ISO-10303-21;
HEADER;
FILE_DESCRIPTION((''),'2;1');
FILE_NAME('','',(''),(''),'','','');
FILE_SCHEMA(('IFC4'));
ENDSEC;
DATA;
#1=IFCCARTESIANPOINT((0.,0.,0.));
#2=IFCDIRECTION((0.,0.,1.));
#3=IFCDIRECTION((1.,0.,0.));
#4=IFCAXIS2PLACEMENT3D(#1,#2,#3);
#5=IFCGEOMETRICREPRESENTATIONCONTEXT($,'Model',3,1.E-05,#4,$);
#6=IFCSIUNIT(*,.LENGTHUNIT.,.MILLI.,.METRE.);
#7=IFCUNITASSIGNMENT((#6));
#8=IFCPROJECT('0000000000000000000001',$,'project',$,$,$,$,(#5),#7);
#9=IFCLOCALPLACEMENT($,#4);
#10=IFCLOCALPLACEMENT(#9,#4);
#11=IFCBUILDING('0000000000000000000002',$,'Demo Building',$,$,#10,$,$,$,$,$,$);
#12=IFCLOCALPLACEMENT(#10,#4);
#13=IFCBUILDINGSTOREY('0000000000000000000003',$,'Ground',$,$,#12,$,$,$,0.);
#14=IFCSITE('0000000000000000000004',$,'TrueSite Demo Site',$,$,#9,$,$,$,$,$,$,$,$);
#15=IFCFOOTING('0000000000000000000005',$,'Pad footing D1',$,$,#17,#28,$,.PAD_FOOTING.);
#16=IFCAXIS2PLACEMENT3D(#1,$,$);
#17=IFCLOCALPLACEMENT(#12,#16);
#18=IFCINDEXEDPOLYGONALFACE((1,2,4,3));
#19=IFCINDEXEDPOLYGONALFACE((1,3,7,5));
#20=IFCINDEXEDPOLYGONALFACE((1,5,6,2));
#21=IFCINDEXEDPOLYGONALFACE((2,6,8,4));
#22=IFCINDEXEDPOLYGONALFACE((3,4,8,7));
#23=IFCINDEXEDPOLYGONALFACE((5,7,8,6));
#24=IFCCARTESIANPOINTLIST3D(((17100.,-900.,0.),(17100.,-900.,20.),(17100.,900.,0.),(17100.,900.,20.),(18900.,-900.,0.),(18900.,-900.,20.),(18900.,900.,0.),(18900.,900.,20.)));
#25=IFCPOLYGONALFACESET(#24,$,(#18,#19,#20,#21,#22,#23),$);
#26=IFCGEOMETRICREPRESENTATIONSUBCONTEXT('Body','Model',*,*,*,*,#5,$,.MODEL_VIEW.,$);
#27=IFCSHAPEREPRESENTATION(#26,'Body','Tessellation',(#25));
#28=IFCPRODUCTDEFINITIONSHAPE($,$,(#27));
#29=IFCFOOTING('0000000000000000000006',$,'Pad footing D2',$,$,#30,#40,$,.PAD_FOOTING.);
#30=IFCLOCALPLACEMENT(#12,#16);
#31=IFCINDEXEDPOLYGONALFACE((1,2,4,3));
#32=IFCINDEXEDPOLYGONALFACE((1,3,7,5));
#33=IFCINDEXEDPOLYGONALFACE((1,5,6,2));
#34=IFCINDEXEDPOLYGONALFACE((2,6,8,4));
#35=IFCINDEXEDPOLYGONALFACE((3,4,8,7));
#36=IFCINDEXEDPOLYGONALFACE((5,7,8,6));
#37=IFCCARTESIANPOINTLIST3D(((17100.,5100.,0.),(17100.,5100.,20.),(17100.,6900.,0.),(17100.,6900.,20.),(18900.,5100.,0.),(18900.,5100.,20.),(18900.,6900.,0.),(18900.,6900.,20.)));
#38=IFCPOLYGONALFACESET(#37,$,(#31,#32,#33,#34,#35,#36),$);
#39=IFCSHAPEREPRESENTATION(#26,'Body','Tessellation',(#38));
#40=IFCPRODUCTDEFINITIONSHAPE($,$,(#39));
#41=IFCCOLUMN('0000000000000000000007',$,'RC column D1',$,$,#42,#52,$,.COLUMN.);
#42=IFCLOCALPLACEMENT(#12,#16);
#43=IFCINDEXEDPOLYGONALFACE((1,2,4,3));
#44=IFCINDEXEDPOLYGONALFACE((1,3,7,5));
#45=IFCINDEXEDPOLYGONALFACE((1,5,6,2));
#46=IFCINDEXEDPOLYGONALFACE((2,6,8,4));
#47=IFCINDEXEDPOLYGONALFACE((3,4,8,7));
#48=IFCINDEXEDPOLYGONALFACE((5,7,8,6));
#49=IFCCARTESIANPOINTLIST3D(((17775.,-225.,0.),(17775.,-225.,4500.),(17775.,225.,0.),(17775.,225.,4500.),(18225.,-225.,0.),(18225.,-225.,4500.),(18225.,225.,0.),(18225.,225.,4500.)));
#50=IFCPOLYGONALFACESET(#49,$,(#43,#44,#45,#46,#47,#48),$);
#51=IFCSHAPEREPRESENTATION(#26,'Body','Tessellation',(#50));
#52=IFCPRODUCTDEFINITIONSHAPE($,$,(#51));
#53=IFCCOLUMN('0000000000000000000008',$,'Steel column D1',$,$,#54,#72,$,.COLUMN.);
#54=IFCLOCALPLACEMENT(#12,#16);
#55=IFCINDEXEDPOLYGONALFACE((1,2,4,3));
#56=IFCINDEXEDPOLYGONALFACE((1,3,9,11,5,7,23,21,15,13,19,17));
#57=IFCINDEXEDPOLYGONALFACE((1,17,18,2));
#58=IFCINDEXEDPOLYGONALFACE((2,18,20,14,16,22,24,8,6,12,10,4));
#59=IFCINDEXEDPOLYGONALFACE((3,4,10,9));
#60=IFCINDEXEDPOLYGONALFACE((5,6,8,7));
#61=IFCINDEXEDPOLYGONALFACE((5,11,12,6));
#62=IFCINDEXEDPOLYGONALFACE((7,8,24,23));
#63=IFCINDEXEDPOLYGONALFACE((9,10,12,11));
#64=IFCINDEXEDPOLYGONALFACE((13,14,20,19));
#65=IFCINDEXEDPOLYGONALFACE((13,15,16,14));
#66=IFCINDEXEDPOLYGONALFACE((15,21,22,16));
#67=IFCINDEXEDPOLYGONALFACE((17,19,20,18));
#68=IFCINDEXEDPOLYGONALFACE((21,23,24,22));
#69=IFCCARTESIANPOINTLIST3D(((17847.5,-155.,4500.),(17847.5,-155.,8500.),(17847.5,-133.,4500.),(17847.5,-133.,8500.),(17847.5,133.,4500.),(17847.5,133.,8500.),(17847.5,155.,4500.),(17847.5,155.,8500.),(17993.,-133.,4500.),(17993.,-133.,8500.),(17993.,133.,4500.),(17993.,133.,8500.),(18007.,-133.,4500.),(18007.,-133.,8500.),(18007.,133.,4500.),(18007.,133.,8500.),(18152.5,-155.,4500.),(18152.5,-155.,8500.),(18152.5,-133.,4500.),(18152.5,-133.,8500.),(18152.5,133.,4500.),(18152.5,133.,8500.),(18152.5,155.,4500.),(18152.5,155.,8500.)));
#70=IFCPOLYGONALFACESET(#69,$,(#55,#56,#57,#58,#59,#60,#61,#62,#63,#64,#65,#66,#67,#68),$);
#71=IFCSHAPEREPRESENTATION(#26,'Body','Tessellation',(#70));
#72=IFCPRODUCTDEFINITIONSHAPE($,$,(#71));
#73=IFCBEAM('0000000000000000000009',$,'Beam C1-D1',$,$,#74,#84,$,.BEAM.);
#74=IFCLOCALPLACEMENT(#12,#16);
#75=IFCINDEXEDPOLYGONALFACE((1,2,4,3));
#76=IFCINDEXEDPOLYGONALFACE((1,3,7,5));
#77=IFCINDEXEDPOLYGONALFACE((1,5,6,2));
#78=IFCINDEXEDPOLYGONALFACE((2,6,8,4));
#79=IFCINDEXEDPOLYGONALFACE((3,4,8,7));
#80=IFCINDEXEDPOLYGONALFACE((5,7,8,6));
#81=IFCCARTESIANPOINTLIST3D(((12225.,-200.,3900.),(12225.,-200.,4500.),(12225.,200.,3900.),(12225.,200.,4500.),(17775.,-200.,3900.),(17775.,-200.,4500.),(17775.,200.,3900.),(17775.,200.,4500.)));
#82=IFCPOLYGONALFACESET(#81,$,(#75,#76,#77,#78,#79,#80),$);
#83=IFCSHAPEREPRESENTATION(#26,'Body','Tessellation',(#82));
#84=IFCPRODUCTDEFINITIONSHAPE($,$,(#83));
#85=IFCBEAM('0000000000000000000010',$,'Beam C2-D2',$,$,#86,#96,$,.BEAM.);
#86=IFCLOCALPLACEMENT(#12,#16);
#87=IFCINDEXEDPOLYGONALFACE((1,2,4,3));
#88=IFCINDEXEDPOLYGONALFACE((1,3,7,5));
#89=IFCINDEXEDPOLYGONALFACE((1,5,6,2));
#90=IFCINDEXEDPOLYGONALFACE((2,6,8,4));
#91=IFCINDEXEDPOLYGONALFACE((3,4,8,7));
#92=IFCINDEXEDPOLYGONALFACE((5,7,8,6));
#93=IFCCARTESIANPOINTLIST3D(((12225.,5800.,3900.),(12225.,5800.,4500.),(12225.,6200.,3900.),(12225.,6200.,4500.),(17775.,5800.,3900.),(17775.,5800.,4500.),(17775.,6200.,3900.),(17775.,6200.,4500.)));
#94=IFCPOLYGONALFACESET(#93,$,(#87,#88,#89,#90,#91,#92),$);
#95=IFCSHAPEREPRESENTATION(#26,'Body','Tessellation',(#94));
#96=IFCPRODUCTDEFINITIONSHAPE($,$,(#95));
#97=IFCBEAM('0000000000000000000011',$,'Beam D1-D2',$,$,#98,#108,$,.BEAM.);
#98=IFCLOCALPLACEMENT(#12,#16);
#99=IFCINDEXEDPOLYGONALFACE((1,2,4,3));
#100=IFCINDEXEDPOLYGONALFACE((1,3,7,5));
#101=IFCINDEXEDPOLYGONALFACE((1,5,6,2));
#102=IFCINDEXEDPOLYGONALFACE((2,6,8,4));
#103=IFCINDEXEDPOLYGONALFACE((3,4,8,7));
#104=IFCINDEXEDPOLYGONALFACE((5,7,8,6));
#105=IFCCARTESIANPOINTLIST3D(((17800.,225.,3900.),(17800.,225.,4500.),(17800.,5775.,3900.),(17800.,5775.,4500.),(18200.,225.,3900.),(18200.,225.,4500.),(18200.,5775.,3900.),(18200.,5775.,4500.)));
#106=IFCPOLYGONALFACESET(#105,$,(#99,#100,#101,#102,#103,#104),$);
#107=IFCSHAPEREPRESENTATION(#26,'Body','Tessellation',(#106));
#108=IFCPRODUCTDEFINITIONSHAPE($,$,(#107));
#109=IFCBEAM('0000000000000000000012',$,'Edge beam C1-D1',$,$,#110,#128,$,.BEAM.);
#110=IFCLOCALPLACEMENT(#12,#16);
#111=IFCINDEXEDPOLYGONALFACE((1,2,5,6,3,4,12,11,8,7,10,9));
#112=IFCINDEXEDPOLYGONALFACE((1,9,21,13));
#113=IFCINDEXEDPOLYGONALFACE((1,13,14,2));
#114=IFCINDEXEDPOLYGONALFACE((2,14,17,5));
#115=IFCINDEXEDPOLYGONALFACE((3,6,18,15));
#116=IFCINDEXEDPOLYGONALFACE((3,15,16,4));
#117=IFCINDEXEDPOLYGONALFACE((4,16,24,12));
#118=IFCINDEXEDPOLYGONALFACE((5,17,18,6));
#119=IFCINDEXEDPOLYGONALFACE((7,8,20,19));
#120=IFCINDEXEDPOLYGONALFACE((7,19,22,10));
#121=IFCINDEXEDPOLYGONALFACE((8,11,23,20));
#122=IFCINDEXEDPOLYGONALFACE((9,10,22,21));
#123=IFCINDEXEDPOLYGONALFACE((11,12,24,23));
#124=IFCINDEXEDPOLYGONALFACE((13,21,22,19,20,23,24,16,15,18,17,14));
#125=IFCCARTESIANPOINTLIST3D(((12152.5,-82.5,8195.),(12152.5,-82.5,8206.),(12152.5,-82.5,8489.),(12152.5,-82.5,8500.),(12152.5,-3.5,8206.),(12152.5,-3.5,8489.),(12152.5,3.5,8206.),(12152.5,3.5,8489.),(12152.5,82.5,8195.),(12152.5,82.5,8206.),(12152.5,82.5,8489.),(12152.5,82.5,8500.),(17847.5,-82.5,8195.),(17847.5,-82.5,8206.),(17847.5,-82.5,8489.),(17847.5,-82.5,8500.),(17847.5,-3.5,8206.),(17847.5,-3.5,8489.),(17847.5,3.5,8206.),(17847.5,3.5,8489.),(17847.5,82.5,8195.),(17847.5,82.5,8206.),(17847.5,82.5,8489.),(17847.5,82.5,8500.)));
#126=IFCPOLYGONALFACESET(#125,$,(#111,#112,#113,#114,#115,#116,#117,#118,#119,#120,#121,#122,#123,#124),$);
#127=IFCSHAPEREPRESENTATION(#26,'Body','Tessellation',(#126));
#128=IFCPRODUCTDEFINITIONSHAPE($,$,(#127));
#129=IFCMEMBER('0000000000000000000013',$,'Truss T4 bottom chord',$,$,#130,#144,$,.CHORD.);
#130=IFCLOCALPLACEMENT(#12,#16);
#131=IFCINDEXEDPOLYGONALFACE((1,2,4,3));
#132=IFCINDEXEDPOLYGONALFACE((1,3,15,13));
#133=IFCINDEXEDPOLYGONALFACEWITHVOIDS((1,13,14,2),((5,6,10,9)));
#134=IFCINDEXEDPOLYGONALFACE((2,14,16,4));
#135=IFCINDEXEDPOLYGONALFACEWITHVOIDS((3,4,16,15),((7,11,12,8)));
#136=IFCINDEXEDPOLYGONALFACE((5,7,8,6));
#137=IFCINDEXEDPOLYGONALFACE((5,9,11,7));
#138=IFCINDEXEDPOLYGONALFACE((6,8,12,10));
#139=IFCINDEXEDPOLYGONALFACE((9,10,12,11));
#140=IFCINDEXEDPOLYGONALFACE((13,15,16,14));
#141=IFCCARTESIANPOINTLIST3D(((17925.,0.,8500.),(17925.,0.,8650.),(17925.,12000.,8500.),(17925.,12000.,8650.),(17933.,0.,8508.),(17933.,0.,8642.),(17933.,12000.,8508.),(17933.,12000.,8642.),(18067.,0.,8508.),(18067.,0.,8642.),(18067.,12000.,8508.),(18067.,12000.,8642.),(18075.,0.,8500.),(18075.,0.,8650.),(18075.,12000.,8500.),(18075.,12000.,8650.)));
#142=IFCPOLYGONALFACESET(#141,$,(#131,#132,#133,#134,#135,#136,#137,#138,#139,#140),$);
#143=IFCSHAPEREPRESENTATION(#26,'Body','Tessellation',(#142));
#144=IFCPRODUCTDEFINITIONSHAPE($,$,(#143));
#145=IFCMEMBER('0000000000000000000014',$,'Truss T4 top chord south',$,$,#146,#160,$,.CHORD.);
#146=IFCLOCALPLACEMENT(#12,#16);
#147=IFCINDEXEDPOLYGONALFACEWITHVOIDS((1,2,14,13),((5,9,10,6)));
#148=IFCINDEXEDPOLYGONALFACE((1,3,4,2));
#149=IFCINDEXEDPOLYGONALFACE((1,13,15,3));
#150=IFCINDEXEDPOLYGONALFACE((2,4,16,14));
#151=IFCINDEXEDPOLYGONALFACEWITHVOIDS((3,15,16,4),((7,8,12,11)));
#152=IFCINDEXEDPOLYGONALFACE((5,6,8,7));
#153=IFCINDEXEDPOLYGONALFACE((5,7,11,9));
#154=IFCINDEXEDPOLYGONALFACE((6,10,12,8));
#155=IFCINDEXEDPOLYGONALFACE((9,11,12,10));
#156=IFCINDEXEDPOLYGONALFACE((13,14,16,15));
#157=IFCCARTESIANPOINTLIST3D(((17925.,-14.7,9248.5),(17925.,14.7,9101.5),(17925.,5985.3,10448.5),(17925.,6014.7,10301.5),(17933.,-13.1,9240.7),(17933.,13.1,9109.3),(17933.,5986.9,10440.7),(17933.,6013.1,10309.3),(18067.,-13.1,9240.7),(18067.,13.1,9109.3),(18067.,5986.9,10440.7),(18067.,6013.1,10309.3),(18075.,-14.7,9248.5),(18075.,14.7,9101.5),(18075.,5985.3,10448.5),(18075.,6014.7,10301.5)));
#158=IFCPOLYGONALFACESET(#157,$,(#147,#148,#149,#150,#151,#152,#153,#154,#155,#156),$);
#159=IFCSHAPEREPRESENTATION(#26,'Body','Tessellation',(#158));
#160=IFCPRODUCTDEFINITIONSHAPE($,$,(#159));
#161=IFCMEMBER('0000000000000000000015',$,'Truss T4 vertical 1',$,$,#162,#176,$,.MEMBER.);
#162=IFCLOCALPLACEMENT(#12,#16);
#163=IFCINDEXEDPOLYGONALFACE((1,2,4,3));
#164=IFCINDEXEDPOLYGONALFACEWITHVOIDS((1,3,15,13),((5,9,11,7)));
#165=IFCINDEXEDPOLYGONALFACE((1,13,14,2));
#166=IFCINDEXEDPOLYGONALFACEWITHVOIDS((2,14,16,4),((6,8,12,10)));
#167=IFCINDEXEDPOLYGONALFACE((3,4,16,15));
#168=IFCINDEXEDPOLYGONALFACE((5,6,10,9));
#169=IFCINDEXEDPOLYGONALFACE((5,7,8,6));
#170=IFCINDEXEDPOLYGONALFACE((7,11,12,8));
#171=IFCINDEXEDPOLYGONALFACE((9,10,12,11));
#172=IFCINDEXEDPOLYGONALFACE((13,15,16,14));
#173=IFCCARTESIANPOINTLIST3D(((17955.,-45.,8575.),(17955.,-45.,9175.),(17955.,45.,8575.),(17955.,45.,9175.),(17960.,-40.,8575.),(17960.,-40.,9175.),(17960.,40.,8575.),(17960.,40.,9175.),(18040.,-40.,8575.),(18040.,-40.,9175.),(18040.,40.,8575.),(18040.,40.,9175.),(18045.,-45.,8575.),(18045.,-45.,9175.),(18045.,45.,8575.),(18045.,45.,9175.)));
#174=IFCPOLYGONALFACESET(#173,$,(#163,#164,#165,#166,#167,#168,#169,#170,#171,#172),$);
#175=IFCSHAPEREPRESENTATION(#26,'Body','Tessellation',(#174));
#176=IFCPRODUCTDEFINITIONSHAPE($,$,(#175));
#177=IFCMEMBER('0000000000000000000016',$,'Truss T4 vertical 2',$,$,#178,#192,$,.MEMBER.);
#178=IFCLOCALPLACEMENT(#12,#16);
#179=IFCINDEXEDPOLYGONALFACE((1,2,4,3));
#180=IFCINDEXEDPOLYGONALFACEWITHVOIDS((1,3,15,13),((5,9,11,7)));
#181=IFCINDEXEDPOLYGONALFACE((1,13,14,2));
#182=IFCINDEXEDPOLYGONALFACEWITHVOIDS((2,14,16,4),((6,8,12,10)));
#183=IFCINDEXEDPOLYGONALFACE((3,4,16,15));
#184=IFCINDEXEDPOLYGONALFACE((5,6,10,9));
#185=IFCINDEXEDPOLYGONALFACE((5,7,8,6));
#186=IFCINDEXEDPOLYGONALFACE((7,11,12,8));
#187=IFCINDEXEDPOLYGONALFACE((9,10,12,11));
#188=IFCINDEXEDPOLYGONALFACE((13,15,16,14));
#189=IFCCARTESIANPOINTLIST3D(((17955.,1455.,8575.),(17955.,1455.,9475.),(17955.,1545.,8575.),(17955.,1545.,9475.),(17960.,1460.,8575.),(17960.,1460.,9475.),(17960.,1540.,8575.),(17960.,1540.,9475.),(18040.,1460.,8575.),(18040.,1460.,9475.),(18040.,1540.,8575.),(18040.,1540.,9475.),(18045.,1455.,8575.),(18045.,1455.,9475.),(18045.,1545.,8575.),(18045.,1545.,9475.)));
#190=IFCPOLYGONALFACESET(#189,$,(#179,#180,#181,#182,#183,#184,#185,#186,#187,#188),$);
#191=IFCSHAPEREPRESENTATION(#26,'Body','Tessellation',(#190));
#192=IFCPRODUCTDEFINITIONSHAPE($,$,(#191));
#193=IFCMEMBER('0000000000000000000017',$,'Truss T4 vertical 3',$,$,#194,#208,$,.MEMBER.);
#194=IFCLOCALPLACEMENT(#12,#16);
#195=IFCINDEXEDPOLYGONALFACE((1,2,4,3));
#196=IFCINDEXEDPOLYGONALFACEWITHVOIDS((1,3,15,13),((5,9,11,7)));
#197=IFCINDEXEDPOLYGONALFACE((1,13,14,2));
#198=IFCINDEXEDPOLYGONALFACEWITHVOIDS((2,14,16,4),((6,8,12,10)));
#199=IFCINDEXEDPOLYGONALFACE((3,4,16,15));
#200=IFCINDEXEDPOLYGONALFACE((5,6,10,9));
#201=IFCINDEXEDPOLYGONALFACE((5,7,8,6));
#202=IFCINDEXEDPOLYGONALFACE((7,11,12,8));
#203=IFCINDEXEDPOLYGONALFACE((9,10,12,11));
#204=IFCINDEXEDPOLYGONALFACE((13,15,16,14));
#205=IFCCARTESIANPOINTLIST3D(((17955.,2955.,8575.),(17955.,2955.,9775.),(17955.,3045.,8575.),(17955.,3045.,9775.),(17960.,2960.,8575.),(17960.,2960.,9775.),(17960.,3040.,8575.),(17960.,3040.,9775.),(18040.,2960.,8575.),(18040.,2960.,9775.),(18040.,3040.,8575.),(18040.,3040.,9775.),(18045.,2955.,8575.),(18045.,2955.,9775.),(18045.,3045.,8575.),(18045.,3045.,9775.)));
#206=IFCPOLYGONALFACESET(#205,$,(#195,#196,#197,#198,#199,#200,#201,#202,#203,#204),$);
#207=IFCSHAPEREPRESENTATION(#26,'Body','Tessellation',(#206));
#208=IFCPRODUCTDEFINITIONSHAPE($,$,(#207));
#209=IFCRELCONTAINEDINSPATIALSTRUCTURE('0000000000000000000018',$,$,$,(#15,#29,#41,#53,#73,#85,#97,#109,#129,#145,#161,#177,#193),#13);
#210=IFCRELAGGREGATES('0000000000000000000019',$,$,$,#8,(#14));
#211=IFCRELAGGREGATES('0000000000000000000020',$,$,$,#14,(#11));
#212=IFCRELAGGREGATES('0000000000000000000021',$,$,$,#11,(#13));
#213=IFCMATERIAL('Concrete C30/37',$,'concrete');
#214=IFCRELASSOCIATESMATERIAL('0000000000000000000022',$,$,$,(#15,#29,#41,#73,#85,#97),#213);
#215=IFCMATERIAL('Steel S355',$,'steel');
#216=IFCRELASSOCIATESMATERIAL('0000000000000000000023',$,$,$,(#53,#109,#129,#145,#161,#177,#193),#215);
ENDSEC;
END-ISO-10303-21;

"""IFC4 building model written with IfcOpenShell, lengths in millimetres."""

from ifc_helpers import new_model, si_unit, frame, origin_with_axes, place, context, subcontext, project, spatial, rectangle, hollow_rectangle, i_section, extrude, material, element, save


model = new_model("IFC4")

# Units and contexts
model_context = context("Model", 3, precision=1e-05, world=origin_with_axes())
body_context = subcontext(model_context, "Body", "Model", "MODEL_VIEW")
ifc_project = project(units=[si_unit("LENGTHUNIT", "METRE", prefix="MILLI")], contexts=[model_context])

# Site, building, storey
site_placement = place(None, origin_with_axes())
site = spatial("IfcSite", under=ifc_project, at=site_placement, Name="TrueSite Demo Site")
building_placement = place(site_placement, origin_with_axes())
building = spatial("IfcBuilding", under=site, at=building_placement, Name="Demo Building")
storey_placement = place(building_placement, origin_with_axes())
storey = spatial("IfcBuildingStorey", under=building, at=storey_placement, Name="Ground", Elevation=0.0)

# Footings
ifc_material_1 = material(Name="Concrete C30/37", Category="concrete")
for number, where, z_axis, x_axis, name in (
    (1, (18000.0, 0.0, 0.0), (0.0, 0.0, 1.0), (1.0, 0.0, 0.0), "Pad footing D1"),
    (2, (18000.0, 6000.0, 0.0), (0.0, 0.0, 1.0), (1.0, 0.0, 0.0), "Pad footing D2"),
):
    element("IfcFooting", number, at=place(storey_placement, frame(where, z_axis=z_axis, x_axis=x_axis)), inside=storey, material=ifc_material_1, Name=name, PredefinedType="PAD_FOOTING", context=body_context, shape_type="SweptSolid", body=[
        extrude(rectangle(XDim=1800.0, YDim=1800.0), origin_with_axes(), (0.0, 0.0, 1.0), 20.0),
    ])

# Columns
column_1_placement = place(storey_placement, frame((18000.0, 0.0, 0.0), z_axis=(0.0, 0.0, 1.0), x_axis=(1.0, 0.0, 0.0)))
element("IfcColumn", 3, at=column_1_placement, inside=storey, material=ifc_material_1, Name="RC column D1", PredefinedType="COLUMN", context=body_context, shape_type="SweptSolid", body=[
    extrude(rectangle(XDim=450.0, YDim=450.0), origin_with_axes(), (0.0, 0.0, 1.0), 4500.0),
])
ifc_material_2 = material(Name="Steel S355", Category="steel")
column_2_placement = place(storey_placement, frame((18000.0, 0.0, 4500.0), z_axis=(0.0, 0.0, 1.0), x_axis=(1.0, 0.0, 0.0)))
element("IfcColumn", 4, at=column_2_placement, inside=storey, material=ifc_material_2, Name="Steel column D1", PredefinedType="COLUMN", context=body_context, shape_type="SweptSolid", body=[
    extrude(i_section(OverallWidth=305.0, OverallDepth=310.0, WebThickness=14.0, FlangeThickness=22.0), origin_with_axes(), (0.0, 0.0, 1.0), 4000.0),
])

# Beams
for number, where, z_axis, x_axis, name in (
    (5, (12225.0, 0.0, 4200.0), (1.0, 0.0, 0.0), (0.0, 1.0, 0.0), "Beam C1-D1"),
    (6, (12225.0, 6000.0, 4200.0), (1.0, 0.0, 0.0), (0.0, 1.0, 0.0), "Beam C2-D2"),
):
    element("IfcBeam", number, at=place(storey_placement, frame(where, z_axis=z_axis, x_axis=x_axis)), inside=storey, material=ifc_material_1, Name=name, PredefinedType="BEAM", context=body_context, shape_type="SweptSolid", body=[
        extrude(rectangle(XDim=400.0, YDim=600.0), origin_with_axes(), (0.0, 0.0, 1.0), 5550.0),
    ])
beam_1_placement = place(storey_placement, frame((18000.0, 225.0, 4200.0), z_axis=(0.0, 1.0, 0.0), x_axis=(-1.0, 0.0, 0.0)))
element("IfcBeam", 7, at=beam_1_placement, inside=storey, material=ifc_material_1, Name="Beam D1-D2", PredefinedType="BEAM", context=body_context, shape_type="SweptSolid", body=[
    extrude(rectangle(XDim=400.0, YDim=600.0), origin_with_axes(), (0.0, 0.0, 1.0), 5550.0),
])
beam_2_placement = place(storey_placement, frame((12152.5, 0.0, 8347.5), z_axis=(1.0, 0.0, 0.0), x_axis=(0.0, 1.0, 0.0)))
element("IfcBeam", 8, at=beam_2_placement, inside=storey, material=ifc_material_2, Name="Edge beam C1-D1", PredefinedType="BEAM", context=body_context, shape_type="SweptSolid", body=[
    extrude(i_section(OverallWidth=165.0, OverallDepth=305.0, WebThickness=7.0, FlangeThickness=11.0), origin_with_axes(), (0.0, 0.0, 1.0), 5695.0),
])

# Members
member_1_placement = place(storey_placement, frame((18000.0, 0.0, 8575.0), z_axis=(0.0, 1.0, 0.0), x_axis=(-1.0, 0.0, 0.0)))
element("IfcMember", 9, at=member_1_placement, inside=storey, material=ifc_material_2, Name="Truss T4 bottom chord", PredefinedType="CHORD", context=body_context, shape_type="SweptSolid", body=[
    extrude(hollow_rectangle(XDim=150.0, YDim=150.0, WallThickness=8.0), origin_with_axes(), (0.0, 0.0, 1.0), 12000.0),
])
member_2_placement = place(storey_placement, frame((18000.0, 0.0, 9175.0), z_axis=(0.0, 0.980581, 0.196116), x_axis=(-1.0, 0.0, 0.0)))
element("IfcMember", 10, at=member_2_placement, inside=storey, material=ifc_material_2, Name="Truss T4 top chord south", PredefinedType="CHORD", context=body_context, shape_type="SweptSolid", body=[
    extrude(hollow_rectangle(XDim=150.0, YDim=150.0, WallThickness=8.0), origin_with_axes(), (0.0, 0.0, 1.0), 6118.8),
])
member_3_placement = place(storey_placement, frame((18000.0, 0.0, 8575.0), z_axis=(0.0, 0.0, 1.0), x_axis=(1.0, 0.0, 0.0)))
element("IfcMember", 11, at=member_3_placement, inside=storey, material=ifc_material_2, Name="Truss T4 vertical 1", PredefinedType="MEMBER", context=body_context, shape_type="SweptSolid", body=[
    extrude(hollow_rectangle(XDim=90.0, YDim=90.0, WallThickness=5.0), origin_with_axes(), (0.0, 0.0, 1.0), 600.0),
])
member_4_placement = place(storey_placement, frame((18000.0, 1500.0, 8575.0), z_axis=(0.0, 0.0, 1.0), x_axis=(1.0, 0.0, 0.0)))
element("IfcMember", 12, at=member_4_placement, inside=storey, material=ifc_material_2, Name="Truss T4 vertical 2", PredefinedType="MEMBER", context=body_context, shape_type="SweptSolid", body=[
    extrude(hollow_rectangle(XDim=90.0, YDim=90.0, WallThickness=5.0), origin_with_axes(), (0.0, 0.0, 1.0), 900.0),
])
member_5_placement = place(storey_placement, frame((18000.0, 3000.0, 8575.0), z_axis=(0.0, 0.0, 1.0), x_axis=(1.0, 0.0, 0.0)))
element("IfcMember", 13, at=member_5_placement, inside=storey, material=ifc_material_2, Name="Truss T4 vertical 3", PredefinedType="MEMBER", context=body_context, shape_type="SweptSolid", body=[
    extrude(hollow_rectangle(XDim=90.0, YDim=90.0, WallThickness=5.0), origin_with_axes(), (0.0, 0.0, 1.0), 1200.0),
])

save(model, "model.ifc")
